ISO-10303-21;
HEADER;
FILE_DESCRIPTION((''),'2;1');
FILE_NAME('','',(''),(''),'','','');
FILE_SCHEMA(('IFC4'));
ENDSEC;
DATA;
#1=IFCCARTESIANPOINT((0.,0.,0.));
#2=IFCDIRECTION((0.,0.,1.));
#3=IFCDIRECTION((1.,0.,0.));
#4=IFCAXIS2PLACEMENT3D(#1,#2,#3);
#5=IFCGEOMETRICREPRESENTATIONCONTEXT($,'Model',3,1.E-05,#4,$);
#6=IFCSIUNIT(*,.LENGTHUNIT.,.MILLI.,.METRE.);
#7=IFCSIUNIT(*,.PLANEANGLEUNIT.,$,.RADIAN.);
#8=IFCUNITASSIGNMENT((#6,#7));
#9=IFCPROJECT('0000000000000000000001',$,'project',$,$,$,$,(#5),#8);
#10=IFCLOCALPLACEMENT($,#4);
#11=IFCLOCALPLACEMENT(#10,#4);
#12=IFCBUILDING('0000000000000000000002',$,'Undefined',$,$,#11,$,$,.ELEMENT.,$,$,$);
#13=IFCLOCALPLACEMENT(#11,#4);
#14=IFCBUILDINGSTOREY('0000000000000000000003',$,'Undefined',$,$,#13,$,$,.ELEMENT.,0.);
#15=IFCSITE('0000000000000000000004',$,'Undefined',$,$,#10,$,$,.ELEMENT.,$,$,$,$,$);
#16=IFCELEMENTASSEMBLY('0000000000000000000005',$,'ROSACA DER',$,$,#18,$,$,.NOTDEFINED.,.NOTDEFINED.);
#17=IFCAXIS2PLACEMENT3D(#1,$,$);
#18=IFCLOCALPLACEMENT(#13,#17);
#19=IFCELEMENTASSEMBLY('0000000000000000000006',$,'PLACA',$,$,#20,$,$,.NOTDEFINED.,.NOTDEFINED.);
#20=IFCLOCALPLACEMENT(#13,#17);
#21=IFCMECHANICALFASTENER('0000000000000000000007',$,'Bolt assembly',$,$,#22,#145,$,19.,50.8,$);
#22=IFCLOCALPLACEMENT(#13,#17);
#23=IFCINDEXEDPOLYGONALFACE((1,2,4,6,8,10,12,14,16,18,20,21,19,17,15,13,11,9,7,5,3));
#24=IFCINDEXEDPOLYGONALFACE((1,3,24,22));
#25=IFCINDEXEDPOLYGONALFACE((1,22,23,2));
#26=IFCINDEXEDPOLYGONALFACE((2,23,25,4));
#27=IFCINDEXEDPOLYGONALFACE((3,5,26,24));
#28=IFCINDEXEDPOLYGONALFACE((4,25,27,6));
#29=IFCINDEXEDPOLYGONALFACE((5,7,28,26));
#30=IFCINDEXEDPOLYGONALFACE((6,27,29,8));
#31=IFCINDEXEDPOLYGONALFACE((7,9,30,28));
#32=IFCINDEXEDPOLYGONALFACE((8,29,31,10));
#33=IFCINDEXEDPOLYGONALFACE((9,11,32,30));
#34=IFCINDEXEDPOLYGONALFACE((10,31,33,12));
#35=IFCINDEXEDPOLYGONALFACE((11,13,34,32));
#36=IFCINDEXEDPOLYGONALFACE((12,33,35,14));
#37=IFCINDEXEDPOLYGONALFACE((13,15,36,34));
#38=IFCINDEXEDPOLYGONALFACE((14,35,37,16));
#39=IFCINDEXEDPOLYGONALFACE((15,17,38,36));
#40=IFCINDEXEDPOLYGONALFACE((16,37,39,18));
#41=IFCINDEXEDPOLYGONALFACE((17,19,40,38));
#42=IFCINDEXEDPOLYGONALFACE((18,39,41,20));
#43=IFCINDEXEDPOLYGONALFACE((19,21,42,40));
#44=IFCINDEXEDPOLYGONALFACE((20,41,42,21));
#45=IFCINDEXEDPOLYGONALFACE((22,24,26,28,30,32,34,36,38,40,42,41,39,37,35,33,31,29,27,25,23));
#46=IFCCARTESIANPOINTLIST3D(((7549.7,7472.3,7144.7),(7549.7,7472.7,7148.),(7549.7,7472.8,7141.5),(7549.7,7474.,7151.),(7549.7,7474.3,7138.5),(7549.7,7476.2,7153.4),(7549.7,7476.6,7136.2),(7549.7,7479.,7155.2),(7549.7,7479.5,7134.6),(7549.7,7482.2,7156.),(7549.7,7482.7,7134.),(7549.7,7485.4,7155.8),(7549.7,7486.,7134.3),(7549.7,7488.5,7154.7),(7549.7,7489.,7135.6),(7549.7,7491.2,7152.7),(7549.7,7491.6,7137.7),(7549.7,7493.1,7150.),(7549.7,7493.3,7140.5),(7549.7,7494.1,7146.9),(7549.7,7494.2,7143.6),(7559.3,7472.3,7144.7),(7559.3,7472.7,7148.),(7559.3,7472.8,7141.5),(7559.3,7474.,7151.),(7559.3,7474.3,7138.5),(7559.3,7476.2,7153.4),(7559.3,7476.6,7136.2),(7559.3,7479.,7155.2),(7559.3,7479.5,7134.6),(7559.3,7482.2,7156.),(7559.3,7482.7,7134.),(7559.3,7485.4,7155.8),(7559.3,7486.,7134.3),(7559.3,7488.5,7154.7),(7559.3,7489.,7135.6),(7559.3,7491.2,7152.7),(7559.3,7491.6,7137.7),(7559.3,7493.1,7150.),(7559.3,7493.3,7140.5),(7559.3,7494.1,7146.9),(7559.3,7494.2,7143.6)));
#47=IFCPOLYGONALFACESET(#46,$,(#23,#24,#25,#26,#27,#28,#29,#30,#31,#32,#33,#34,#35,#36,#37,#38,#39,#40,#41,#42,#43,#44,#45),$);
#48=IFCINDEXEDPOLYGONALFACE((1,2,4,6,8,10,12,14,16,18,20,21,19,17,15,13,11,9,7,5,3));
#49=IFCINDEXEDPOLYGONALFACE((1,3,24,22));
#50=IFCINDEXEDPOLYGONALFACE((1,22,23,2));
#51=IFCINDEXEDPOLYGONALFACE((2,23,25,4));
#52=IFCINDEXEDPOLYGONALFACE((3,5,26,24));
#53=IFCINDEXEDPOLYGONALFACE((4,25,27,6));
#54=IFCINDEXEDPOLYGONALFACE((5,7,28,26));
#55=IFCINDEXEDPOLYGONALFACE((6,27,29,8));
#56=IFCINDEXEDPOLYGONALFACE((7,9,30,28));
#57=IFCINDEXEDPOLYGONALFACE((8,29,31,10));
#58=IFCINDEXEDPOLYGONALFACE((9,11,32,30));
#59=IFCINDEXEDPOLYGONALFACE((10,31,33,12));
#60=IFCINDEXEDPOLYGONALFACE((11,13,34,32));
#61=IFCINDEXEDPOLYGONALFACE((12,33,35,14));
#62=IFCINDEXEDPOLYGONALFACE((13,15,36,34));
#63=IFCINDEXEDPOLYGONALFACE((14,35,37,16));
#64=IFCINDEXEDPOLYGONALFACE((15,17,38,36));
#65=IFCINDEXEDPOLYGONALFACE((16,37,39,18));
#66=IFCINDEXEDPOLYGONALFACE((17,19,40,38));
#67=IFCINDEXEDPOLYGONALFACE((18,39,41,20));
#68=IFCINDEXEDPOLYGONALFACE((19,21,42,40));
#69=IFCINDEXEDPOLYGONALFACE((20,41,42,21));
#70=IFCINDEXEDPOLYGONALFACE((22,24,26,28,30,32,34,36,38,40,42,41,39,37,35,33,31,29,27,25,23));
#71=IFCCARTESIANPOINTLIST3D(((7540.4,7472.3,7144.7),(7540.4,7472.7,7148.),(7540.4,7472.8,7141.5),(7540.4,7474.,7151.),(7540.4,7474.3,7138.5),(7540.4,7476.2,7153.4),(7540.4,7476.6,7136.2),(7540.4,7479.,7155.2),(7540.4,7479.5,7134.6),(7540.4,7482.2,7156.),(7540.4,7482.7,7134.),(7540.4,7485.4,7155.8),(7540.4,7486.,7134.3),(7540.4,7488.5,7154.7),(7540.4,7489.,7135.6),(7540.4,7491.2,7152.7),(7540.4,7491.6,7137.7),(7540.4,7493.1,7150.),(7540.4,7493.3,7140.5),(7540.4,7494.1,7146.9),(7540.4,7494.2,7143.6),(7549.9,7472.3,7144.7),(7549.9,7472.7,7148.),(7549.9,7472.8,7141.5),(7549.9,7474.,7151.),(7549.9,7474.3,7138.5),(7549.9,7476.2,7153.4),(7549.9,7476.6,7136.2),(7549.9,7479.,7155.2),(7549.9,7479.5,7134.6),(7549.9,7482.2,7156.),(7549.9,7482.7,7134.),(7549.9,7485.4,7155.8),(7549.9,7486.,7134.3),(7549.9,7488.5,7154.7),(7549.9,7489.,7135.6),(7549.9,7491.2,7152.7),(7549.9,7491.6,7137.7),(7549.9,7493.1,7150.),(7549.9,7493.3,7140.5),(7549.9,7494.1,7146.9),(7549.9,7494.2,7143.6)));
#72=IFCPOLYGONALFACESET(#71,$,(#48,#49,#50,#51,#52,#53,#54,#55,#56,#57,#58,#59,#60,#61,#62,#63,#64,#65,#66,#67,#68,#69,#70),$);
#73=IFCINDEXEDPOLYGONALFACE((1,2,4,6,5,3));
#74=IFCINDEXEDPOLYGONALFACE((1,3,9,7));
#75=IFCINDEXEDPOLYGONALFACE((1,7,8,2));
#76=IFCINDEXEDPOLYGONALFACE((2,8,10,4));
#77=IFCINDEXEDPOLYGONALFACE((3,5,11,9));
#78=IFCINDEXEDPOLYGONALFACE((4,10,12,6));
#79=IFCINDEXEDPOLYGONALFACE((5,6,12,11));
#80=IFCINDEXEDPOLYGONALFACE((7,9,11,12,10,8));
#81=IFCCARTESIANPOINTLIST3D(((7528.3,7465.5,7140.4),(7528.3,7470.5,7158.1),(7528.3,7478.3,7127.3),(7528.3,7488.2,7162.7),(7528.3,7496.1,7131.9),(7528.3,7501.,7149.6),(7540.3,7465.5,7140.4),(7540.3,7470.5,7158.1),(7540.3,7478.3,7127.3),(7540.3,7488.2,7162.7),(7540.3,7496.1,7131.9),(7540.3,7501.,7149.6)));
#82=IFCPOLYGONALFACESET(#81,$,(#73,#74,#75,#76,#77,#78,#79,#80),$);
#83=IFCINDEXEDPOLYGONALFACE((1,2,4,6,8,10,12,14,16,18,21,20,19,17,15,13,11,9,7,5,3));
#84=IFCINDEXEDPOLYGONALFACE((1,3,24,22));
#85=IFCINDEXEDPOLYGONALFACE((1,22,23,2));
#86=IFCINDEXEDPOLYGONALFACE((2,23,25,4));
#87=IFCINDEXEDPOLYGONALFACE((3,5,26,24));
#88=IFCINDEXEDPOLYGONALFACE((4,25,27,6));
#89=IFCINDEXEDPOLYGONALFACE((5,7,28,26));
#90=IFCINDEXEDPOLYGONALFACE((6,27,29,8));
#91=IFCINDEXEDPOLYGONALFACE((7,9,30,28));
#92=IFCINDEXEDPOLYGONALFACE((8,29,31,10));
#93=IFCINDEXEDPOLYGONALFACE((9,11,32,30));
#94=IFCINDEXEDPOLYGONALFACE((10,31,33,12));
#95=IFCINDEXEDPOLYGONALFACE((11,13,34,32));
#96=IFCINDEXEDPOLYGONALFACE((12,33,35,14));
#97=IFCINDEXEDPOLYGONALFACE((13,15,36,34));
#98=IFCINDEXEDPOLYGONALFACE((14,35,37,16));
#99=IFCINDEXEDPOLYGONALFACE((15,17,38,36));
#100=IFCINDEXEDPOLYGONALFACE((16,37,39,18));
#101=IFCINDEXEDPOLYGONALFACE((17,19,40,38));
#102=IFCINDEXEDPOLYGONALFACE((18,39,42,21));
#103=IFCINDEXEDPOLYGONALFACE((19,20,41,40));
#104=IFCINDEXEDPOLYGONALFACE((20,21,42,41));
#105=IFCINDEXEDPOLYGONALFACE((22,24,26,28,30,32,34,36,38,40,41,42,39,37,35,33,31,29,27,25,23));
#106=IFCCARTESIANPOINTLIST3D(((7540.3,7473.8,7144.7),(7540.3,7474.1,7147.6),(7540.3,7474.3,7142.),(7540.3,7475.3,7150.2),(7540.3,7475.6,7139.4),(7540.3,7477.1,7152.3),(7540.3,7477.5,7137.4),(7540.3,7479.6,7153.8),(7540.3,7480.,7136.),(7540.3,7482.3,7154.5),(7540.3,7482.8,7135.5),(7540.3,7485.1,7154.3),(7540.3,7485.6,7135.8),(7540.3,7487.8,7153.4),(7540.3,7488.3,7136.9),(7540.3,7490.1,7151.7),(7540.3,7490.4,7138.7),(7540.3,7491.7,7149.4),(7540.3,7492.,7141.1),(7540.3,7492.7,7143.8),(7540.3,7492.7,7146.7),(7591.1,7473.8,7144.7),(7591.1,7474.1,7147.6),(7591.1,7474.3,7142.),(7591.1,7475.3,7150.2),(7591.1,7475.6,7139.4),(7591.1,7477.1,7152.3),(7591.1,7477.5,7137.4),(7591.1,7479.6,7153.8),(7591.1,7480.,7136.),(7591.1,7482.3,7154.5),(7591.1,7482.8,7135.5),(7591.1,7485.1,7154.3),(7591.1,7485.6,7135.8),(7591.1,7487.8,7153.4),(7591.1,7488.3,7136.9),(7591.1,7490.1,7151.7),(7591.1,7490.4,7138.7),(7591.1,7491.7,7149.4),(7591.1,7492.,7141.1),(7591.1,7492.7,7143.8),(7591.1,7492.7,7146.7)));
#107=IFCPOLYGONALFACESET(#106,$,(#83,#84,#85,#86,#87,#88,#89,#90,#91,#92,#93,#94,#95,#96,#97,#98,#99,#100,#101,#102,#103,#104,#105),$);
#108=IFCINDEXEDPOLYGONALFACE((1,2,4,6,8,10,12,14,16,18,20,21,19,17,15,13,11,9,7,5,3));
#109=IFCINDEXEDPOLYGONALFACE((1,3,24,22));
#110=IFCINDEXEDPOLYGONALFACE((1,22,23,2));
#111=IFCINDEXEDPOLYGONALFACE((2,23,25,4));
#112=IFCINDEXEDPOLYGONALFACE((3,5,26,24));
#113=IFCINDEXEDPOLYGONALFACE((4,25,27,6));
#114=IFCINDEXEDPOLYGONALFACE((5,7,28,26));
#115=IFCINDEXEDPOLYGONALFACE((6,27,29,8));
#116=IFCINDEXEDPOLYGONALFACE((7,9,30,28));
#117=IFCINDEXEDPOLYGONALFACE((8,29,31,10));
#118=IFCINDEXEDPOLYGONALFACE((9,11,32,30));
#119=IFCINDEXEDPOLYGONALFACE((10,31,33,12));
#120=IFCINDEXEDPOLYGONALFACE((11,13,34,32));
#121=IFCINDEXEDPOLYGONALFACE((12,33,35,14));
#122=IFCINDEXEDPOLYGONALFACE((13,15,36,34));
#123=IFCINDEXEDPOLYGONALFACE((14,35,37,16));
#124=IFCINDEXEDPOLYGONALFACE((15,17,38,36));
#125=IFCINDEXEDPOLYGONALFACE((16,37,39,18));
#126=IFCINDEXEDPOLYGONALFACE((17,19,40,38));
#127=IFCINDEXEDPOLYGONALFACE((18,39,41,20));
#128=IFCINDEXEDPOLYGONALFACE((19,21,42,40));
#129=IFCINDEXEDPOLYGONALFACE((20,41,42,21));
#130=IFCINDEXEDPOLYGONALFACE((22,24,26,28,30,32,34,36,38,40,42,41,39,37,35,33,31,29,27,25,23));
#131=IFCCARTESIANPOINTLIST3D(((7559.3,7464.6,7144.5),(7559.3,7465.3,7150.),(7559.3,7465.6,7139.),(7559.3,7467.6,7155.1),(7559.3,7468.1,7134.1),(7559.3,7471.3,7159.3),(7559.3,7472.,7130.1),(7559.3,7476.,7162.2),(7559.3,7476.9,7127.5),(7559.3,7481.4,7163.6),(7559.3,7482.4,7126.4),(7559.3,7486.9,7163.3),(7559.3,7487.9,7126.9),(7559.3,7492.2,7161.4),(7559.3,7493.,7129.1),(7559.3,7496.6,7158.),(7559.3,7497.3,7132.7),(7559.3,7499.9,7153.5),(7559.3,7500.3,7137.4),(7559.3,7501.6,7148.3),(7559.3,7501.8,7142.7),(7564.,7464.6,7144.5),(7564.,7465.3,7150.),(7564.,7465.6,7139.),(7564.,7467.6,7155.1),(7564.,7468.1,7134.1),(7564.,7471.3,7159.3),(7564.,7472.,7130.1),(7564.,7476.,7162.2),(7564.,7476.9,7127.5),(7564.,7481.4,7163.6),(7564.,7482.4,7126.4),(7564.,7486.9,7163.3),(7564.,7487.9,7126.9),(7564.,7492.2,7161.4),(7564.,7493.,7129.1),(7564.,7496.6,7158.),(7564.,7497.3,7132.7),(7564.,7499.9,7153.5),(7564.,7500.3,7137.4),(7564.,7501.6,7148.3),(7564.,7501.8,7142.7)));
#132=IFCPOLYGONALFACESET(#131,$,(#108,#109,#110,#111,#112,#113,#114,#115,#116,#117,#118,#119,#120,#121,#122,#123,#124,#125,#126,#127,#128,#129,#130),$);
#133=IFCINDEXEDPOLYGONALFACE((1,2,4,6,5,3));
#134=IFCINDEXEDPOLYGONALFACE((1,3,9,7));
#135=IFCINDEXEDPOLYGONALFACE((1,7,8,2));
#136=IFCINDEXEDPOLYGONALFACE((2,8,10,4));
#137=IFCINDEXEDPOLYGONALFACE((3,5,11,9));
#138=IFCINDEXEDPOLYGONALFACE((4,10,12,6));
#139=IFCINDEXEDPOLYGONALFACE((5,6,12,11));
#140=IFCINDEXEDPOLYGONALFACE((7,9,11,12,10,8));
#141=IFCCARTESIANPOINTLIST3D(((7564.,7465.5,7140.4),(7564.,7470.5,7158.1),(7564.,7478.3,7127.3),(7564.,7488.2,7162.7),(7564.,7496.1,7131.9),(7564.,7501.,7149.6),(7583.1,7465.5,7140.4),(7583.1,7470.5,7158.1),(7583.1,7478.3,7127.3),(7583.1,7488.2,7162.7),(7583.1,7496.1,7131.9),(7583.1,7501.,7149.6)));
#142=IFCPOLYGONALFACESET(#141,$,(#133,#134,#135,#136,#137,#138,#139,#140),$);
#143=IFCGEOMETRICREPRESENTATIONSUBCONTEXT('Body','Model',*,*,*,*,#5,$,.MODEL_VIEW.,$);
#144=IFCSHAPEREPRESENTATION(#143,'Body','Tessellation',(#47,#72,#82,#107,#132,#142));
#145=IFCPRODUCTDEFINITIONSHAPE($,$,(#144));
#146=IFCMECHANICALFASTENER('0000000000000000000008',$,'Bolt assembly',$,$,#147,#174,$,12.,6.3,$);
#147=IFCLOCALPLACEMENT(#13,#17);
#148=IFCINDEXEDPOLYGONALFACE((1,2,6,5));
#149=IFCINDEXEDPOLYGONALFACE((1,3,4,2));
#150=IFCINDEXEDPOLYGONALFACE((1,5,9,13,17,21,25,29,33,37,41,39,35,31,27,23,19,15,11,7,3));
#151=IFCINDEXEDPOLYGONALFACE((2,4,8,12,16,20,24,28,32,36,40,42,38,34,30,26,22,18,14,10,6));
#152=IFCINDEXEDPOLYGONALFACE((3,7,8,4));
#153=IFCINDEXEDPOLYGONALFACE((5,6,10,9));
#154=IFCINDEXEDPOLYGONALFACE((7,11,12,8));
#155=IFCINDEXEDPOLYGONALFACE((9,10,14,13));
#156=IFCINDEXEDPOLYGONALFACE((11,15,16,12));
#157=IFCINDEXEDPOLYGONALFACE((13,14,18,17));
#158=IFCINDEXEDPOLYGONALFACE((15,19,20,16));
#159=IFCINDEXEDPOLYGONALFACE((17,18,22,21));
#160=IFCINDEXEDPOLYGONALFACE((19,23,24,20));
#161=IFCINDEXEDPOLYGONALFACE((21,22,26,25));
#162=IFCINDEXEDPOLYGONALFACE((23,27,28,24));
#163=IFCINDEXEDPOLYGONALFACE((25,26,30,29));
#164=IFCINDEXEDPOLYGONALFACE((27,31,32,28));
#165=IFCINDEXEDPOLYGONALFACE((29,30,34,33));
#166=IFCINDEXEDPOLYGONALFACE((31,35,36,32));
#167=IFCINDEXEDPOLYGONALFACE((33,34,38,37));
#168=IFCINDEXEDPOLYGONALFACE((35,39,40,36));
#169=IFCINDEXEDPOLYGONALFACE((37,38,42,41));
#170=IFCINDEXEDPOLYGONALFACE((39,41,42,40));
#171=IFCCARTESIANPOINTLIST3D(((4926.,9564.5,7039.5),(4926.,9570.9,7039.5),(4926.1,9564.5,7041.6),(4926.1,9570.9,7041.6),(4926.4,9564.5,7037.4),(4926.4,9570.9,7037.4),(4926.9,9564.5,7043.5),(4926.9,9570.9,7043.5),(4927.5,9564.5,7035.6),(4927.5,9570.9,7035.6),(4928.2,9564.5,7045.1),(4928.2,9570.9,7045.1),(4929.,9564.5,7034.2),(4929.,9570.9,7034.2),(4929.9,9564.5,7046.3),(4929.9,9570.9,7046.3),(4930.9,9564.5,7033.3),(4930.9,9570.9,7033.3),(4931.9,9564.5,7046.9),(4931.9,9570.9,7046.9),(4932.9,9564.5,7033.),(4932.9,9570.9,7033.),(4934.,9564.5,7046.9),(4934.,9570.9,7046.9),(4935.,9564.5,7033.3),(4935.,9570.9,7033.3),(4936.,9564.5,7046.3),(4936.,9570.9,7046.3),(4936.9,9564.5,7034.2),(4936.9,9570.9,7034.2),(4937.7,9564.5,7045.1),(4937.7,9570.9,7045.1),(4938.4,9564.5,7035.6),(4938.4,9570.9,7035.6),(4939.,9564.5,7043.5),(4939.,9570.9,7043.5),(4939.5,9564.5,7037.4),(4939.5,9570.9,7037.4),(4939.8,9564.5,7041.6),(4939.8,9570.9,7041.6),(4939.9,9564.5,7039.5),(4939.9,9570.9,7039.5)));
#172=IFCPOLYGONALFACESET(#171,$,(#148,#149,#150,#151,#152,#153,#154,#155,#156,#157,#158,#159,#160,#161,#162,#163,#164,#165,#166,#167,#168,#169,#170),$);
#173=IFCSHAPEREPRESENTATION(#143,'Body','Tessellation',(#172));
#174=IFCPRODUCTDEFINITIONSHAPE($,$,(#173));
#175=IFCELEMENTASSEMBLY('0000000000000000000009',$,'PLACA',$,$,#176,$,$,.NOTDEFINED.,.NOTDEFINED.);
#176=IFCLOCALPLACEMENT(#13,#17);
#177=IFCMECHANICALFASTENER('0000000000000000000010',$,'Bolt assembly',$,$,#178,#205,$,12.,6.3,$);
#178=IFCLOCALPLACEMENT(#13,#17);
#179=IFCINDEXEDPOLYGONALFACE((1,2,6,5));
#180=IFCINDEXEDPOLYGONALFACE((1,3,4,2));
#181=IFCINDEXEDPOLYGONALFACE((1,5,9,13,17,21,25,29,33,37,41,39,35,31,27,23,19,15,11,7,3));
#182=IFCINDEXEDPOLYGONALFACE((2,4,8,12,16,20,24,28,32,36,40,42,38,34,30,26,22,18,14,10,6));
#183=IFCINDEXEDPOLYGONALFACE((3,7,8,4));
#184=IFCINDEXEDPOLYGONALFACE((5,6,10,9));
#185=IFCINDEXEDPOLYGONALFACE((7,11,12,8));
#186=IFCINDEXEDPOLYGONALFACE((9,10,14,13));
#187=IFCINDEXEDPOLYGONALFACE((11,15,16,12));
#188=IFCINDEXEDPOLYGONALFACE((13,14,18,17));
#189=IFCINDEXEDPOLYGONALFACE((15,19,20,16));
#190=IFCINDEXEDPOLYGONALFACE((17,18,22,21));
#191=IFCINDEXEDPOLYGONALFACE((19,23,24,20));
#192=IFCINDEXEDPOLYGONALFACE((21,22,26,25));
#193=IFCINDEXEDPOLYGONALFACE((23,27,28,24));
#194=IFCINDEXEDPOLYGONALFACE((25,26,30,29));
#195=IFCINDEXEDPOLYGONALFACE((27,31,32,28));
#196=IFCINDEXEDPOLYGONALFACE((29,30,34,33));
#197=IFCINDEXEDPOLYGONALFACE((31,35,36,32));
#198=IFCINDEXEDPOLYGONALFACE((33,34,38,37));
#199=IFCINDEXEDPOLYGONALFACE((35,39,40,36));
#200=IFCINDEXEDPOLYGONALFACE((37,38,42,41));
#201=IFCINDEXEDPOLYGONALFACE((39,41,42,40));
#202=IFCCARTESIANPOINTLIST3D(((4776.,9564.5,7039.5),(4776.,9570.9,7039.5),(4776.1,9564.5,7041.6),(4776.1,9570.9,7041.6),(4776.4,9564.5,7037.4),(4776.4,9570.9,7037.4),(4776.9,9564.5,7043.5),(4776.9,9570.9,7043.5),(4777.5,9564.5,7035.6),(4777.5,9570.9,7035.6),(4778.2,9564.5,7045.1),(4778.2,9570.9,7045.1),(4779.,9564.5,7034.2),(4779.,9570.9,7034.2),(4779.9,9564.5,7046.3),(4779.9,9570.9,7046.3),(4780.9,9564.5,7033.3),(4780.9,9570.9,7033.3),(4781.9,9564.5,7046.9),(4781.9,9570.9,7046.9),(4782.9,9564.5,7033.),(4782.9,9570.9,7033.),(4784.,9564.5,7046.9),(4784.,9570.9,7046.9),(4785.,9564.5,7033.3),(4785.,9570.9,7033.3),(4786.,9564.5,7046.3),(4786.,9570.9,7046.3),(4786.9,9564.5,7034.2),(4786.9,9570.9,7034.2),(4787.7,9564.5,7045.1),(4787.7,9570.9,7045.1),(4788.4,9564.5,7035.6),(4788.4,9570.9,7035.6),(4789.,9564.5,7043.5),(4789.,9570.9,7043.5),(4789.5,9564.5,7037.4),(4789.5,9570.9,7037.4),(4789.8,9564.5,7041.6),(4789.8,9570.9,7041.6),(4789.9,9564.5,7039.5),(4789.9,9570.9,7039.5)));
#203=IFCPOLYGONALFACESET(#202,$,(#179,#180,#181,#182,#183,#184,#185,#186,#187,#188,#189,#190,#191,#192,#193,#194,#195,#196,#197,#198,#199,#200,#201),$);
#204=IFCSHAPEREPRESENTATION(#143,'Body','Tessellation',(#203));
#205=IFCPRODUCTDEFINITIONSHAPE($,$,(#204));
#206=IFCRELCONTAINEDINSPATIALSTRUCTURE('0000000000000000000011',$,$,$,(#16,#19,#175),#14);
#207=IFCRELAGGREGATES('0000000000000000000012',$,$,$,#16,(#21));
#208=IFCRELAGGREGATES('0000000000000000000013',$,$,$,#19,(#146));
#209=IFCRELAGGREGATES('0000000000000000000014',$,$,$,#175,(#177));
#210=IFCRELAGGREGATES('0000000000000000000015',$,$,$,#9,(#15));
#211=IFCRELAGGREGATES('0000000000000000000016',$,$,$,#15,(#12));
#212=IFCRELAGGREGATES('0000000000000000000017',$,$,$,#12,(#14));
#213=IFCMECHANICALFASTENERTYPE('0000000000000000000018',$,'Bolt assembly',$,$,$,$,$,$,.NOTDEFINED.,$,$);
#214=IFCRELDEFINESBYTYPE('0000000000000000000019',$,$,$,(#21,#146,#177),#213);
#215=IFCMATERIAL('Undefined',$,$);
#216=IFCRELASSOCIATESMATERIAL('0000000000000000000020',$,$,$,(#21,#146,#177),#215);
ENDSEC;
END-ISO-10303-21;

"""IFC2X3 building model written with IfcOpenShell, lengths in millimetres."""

from ifc_helpers import new_model, si_unit, frame, origin_with_axes, origin_2d_with_axis, place, context, subcontext, project, spatial, polyline, circle, outline, extrude, source, transform, mapped, material, type_object, element, aggregate, save


model = new_model("IFC2X3")

# Units and contexts
model_context = context("Model", 3, precision=1e-05, world=origin_with_axes())
body_context = subcontext(model_context, "Body", "Model", "MODEL_VIEW")
ifc_project = project(units=[si_unit("LENGTHUNIT", "METRE", prefix="MILLI"), si_unit("PLANEANGLEUNIT", "RADIAN")], contexts=[model_context])

# Site, building, storey
site_placement = place(None, origin_with_axes())
site = spatial("IfcSite", under=ifc_project, at=site_placement, Name="Undefined", CompositionType="ELEMENT")
building_placement = place(site_placement, origin_with_axes())
building = spatial("IfcBuilding", under=site, at=building_placement, Name="Undefined", CompositionType="ELEMENT")
storey_placement = place(building_placement, origin_with_axes())
storey = spatial("IfcBuildingStorey", under=building, at=storey_placement, Name="Undefined", CompositionType="ELEMENT", Elevation=0.0)

# Element assembly
assembly_1_placement = place(storey_placement, origin_with_axes())
assembly_1 = element("IfcElementAssembly", 1, at=assembly_1_placement, inside=storey, Name="ROSACA DER", AssemblyPlace="NOTDEFINED", PredefinedType="NOTDEFINED")

# Element assembly
assembly_2_placement = place(storey_placement, origin_with_axes())
assembly_2 = element("IfcElementAssembly", 2, at=assembly_2_placement, inside=storey, Name="PLACA", AssemblyPlace="NOTDEFINED", PredefinedType="NOTDEFINED")

# Shared definitions
ifc_material_1 = material(Name="Undefined")
mechanical_fastener_type = type_object("IfcMechanicalFastenerType", Name="Bolt assembly")

# Mechanical fasteners
shared_shape_1 = source(origin_with_axes(), body_context, "Body", "SweptSolid", [
    extrude(circle(Radius=11.0, at=origin_2d_with_axis()), frame((0.0, 4.6, 0.0), z_axis=(0.0, 1.0, 0.0), x_axis=(1.0, 0.0, 0.0)), (0.0, 0.0, 1.0), 9.6),
    extrude(circle(Radius=11.0, at=origin_2d_with_axis()), frame((0.0, -4.6, 0.0), z_axis=(0.0, 1.0, 0.0), x_axis=(1.0, 0.0, 0.0)), (0.0, 0.0, 1.0), 9.5),
    extrude(outline(polyline([(15.9, -9.2), (15.9, 9.2), (0.0, 18.3), (-15.9, 9.2), (-15.9, -9.2), (0.0, -18.3), (15.9, -9.2)])), frame((0.0, -16.7, 0.0), z_axis=(0.0, 1.0, 0.0), x_axis=(1.0, 0.0, 0.0)), (0.0, 0.0, 1.0), 11.9),
    extrude(circle(Radius=9.5, at=origin_2d_with_axis()), frame((0.0, -4.7, 0.0), z_axis=(0.0, 1.0, 0.0), x_axis=(1.0, 0.0, 0.0)), (0.0, 0.0, 1.0), 50.8),
    extrude(circle(Radius=18.7, at=origin_2d_with_axis()), frame((0.0, 14.2, 0.0), z_axis=(0.0, 1.0, 0.0), x_axis=(1.0, 0.0, 0.0)), (0.0, 0.0, 1.0), 4.8),
    extrude(outline(polyline([(15.9, -9.2), (15.9, 9.2), (0.0, 18.3), (-15.9, 9.2), (-15.9, -9.2), (0.0, -18.3), (15.9, -9.2)])), frame((0.0, 19.0, 0.0), z_axis=(0.0, 1.0, 0.0), x_axis=(1.0, 0.0, 0.0)), (0.0, 0.0, 1.0), 19.1),
])
mechanical_fastener_1_placement = place(assembly_1_placement, frame((7545.0, 7483.3, 7145.0), z_axis=(0.0, 0.269246, 0.963072), x_axis=(0.0, -0.963072, 0.269246)))
mechanical_fastener_1 = element("IfcMechanicalFastener", 3, at=mechanical_fastener_1_placement, type_object=mechanical_fastener_type, material=ifc_material_1, Name="Bolt assembly", NominalDiameter=19.0, NominalLength=50.8, context=body_context, shape_type="MappedRepresentation", body=[
    mapped(shared_shape_1, transform((0.0, 0.0, 0.0))),
])
aggregate(assembly_1, [mechanical_fastener_1])
shared_shape_2 = source(origin_with_axes(), body_context, "Body", "SweptSolid", [
    extrude(circle(Radius=7.0, at=origin_2d_with_axis()), frame((0.0, -16.4, 0.0), z_axis=(0.0, 1.0, 0.0), x_axis=(1.0, 0.0, 0.0)), (0.0, 0.0, 1.0), 6.5),
])
mechanical_fastener_2_placement = place(assembly_2_placement, frame((4932.9, 9580.9, 7040.0), z_axis=(1.0, 0.0, 0.0), x_axis=(0.0, 0.0, -1.0)))
mechanical_fastener_2 = element("IfcMechanicalFastener", 4, at=mechanical_fastener_2_placement, type_object=mechanical_fastener_type, material=ifc_material_1, Name="Bolt assembly", NominalDiameter=12.0, NominalLength=6.3, context=body_context, shape_type="MappedRepresentation", body=[
    mapped(shared_shape_2, transform((0.0, 0.0, 0.0))),
])
aggregate(assembly_2, [mechanical_fastener_2])

# Element assembly, mechanical fastener
assembly_3_placement = place(storey_placement, origin_with_axes())
assembly_3 = element("IfcElementAssembly", 5, at=assembly_3_placement, inside=storey, Name="PLACA", AssemblyPlace="NOTDEFINED", PredefinedType="NOTDEFINED")
mechanical_fastener_3_placement = place(assembly_3_placement, frame((4782.9, 9580.9, 7040.0), z_axis=(1.0, 0.0, 0.0), x_axis=(0.0, 0.0, -1.0)))
mechanical_fastener_3 = element("IfcMechanicalFastener", 6, at=mechanical_fastener_3_placement, type_object=mechanical_fastener_type, material=ifc_material_1, Name="Bolt assembly", NominalDiameter=12.0, NominalLength=6.3, context=body_context, shape_type="MappedRepresentation", body=[
    mapped(shared_shape_2, transform((0.0, 0.0, 0.0))),
])
aggregate(assembly_3, [mechanical_fastener_3])

save(model, "model.ifc")
